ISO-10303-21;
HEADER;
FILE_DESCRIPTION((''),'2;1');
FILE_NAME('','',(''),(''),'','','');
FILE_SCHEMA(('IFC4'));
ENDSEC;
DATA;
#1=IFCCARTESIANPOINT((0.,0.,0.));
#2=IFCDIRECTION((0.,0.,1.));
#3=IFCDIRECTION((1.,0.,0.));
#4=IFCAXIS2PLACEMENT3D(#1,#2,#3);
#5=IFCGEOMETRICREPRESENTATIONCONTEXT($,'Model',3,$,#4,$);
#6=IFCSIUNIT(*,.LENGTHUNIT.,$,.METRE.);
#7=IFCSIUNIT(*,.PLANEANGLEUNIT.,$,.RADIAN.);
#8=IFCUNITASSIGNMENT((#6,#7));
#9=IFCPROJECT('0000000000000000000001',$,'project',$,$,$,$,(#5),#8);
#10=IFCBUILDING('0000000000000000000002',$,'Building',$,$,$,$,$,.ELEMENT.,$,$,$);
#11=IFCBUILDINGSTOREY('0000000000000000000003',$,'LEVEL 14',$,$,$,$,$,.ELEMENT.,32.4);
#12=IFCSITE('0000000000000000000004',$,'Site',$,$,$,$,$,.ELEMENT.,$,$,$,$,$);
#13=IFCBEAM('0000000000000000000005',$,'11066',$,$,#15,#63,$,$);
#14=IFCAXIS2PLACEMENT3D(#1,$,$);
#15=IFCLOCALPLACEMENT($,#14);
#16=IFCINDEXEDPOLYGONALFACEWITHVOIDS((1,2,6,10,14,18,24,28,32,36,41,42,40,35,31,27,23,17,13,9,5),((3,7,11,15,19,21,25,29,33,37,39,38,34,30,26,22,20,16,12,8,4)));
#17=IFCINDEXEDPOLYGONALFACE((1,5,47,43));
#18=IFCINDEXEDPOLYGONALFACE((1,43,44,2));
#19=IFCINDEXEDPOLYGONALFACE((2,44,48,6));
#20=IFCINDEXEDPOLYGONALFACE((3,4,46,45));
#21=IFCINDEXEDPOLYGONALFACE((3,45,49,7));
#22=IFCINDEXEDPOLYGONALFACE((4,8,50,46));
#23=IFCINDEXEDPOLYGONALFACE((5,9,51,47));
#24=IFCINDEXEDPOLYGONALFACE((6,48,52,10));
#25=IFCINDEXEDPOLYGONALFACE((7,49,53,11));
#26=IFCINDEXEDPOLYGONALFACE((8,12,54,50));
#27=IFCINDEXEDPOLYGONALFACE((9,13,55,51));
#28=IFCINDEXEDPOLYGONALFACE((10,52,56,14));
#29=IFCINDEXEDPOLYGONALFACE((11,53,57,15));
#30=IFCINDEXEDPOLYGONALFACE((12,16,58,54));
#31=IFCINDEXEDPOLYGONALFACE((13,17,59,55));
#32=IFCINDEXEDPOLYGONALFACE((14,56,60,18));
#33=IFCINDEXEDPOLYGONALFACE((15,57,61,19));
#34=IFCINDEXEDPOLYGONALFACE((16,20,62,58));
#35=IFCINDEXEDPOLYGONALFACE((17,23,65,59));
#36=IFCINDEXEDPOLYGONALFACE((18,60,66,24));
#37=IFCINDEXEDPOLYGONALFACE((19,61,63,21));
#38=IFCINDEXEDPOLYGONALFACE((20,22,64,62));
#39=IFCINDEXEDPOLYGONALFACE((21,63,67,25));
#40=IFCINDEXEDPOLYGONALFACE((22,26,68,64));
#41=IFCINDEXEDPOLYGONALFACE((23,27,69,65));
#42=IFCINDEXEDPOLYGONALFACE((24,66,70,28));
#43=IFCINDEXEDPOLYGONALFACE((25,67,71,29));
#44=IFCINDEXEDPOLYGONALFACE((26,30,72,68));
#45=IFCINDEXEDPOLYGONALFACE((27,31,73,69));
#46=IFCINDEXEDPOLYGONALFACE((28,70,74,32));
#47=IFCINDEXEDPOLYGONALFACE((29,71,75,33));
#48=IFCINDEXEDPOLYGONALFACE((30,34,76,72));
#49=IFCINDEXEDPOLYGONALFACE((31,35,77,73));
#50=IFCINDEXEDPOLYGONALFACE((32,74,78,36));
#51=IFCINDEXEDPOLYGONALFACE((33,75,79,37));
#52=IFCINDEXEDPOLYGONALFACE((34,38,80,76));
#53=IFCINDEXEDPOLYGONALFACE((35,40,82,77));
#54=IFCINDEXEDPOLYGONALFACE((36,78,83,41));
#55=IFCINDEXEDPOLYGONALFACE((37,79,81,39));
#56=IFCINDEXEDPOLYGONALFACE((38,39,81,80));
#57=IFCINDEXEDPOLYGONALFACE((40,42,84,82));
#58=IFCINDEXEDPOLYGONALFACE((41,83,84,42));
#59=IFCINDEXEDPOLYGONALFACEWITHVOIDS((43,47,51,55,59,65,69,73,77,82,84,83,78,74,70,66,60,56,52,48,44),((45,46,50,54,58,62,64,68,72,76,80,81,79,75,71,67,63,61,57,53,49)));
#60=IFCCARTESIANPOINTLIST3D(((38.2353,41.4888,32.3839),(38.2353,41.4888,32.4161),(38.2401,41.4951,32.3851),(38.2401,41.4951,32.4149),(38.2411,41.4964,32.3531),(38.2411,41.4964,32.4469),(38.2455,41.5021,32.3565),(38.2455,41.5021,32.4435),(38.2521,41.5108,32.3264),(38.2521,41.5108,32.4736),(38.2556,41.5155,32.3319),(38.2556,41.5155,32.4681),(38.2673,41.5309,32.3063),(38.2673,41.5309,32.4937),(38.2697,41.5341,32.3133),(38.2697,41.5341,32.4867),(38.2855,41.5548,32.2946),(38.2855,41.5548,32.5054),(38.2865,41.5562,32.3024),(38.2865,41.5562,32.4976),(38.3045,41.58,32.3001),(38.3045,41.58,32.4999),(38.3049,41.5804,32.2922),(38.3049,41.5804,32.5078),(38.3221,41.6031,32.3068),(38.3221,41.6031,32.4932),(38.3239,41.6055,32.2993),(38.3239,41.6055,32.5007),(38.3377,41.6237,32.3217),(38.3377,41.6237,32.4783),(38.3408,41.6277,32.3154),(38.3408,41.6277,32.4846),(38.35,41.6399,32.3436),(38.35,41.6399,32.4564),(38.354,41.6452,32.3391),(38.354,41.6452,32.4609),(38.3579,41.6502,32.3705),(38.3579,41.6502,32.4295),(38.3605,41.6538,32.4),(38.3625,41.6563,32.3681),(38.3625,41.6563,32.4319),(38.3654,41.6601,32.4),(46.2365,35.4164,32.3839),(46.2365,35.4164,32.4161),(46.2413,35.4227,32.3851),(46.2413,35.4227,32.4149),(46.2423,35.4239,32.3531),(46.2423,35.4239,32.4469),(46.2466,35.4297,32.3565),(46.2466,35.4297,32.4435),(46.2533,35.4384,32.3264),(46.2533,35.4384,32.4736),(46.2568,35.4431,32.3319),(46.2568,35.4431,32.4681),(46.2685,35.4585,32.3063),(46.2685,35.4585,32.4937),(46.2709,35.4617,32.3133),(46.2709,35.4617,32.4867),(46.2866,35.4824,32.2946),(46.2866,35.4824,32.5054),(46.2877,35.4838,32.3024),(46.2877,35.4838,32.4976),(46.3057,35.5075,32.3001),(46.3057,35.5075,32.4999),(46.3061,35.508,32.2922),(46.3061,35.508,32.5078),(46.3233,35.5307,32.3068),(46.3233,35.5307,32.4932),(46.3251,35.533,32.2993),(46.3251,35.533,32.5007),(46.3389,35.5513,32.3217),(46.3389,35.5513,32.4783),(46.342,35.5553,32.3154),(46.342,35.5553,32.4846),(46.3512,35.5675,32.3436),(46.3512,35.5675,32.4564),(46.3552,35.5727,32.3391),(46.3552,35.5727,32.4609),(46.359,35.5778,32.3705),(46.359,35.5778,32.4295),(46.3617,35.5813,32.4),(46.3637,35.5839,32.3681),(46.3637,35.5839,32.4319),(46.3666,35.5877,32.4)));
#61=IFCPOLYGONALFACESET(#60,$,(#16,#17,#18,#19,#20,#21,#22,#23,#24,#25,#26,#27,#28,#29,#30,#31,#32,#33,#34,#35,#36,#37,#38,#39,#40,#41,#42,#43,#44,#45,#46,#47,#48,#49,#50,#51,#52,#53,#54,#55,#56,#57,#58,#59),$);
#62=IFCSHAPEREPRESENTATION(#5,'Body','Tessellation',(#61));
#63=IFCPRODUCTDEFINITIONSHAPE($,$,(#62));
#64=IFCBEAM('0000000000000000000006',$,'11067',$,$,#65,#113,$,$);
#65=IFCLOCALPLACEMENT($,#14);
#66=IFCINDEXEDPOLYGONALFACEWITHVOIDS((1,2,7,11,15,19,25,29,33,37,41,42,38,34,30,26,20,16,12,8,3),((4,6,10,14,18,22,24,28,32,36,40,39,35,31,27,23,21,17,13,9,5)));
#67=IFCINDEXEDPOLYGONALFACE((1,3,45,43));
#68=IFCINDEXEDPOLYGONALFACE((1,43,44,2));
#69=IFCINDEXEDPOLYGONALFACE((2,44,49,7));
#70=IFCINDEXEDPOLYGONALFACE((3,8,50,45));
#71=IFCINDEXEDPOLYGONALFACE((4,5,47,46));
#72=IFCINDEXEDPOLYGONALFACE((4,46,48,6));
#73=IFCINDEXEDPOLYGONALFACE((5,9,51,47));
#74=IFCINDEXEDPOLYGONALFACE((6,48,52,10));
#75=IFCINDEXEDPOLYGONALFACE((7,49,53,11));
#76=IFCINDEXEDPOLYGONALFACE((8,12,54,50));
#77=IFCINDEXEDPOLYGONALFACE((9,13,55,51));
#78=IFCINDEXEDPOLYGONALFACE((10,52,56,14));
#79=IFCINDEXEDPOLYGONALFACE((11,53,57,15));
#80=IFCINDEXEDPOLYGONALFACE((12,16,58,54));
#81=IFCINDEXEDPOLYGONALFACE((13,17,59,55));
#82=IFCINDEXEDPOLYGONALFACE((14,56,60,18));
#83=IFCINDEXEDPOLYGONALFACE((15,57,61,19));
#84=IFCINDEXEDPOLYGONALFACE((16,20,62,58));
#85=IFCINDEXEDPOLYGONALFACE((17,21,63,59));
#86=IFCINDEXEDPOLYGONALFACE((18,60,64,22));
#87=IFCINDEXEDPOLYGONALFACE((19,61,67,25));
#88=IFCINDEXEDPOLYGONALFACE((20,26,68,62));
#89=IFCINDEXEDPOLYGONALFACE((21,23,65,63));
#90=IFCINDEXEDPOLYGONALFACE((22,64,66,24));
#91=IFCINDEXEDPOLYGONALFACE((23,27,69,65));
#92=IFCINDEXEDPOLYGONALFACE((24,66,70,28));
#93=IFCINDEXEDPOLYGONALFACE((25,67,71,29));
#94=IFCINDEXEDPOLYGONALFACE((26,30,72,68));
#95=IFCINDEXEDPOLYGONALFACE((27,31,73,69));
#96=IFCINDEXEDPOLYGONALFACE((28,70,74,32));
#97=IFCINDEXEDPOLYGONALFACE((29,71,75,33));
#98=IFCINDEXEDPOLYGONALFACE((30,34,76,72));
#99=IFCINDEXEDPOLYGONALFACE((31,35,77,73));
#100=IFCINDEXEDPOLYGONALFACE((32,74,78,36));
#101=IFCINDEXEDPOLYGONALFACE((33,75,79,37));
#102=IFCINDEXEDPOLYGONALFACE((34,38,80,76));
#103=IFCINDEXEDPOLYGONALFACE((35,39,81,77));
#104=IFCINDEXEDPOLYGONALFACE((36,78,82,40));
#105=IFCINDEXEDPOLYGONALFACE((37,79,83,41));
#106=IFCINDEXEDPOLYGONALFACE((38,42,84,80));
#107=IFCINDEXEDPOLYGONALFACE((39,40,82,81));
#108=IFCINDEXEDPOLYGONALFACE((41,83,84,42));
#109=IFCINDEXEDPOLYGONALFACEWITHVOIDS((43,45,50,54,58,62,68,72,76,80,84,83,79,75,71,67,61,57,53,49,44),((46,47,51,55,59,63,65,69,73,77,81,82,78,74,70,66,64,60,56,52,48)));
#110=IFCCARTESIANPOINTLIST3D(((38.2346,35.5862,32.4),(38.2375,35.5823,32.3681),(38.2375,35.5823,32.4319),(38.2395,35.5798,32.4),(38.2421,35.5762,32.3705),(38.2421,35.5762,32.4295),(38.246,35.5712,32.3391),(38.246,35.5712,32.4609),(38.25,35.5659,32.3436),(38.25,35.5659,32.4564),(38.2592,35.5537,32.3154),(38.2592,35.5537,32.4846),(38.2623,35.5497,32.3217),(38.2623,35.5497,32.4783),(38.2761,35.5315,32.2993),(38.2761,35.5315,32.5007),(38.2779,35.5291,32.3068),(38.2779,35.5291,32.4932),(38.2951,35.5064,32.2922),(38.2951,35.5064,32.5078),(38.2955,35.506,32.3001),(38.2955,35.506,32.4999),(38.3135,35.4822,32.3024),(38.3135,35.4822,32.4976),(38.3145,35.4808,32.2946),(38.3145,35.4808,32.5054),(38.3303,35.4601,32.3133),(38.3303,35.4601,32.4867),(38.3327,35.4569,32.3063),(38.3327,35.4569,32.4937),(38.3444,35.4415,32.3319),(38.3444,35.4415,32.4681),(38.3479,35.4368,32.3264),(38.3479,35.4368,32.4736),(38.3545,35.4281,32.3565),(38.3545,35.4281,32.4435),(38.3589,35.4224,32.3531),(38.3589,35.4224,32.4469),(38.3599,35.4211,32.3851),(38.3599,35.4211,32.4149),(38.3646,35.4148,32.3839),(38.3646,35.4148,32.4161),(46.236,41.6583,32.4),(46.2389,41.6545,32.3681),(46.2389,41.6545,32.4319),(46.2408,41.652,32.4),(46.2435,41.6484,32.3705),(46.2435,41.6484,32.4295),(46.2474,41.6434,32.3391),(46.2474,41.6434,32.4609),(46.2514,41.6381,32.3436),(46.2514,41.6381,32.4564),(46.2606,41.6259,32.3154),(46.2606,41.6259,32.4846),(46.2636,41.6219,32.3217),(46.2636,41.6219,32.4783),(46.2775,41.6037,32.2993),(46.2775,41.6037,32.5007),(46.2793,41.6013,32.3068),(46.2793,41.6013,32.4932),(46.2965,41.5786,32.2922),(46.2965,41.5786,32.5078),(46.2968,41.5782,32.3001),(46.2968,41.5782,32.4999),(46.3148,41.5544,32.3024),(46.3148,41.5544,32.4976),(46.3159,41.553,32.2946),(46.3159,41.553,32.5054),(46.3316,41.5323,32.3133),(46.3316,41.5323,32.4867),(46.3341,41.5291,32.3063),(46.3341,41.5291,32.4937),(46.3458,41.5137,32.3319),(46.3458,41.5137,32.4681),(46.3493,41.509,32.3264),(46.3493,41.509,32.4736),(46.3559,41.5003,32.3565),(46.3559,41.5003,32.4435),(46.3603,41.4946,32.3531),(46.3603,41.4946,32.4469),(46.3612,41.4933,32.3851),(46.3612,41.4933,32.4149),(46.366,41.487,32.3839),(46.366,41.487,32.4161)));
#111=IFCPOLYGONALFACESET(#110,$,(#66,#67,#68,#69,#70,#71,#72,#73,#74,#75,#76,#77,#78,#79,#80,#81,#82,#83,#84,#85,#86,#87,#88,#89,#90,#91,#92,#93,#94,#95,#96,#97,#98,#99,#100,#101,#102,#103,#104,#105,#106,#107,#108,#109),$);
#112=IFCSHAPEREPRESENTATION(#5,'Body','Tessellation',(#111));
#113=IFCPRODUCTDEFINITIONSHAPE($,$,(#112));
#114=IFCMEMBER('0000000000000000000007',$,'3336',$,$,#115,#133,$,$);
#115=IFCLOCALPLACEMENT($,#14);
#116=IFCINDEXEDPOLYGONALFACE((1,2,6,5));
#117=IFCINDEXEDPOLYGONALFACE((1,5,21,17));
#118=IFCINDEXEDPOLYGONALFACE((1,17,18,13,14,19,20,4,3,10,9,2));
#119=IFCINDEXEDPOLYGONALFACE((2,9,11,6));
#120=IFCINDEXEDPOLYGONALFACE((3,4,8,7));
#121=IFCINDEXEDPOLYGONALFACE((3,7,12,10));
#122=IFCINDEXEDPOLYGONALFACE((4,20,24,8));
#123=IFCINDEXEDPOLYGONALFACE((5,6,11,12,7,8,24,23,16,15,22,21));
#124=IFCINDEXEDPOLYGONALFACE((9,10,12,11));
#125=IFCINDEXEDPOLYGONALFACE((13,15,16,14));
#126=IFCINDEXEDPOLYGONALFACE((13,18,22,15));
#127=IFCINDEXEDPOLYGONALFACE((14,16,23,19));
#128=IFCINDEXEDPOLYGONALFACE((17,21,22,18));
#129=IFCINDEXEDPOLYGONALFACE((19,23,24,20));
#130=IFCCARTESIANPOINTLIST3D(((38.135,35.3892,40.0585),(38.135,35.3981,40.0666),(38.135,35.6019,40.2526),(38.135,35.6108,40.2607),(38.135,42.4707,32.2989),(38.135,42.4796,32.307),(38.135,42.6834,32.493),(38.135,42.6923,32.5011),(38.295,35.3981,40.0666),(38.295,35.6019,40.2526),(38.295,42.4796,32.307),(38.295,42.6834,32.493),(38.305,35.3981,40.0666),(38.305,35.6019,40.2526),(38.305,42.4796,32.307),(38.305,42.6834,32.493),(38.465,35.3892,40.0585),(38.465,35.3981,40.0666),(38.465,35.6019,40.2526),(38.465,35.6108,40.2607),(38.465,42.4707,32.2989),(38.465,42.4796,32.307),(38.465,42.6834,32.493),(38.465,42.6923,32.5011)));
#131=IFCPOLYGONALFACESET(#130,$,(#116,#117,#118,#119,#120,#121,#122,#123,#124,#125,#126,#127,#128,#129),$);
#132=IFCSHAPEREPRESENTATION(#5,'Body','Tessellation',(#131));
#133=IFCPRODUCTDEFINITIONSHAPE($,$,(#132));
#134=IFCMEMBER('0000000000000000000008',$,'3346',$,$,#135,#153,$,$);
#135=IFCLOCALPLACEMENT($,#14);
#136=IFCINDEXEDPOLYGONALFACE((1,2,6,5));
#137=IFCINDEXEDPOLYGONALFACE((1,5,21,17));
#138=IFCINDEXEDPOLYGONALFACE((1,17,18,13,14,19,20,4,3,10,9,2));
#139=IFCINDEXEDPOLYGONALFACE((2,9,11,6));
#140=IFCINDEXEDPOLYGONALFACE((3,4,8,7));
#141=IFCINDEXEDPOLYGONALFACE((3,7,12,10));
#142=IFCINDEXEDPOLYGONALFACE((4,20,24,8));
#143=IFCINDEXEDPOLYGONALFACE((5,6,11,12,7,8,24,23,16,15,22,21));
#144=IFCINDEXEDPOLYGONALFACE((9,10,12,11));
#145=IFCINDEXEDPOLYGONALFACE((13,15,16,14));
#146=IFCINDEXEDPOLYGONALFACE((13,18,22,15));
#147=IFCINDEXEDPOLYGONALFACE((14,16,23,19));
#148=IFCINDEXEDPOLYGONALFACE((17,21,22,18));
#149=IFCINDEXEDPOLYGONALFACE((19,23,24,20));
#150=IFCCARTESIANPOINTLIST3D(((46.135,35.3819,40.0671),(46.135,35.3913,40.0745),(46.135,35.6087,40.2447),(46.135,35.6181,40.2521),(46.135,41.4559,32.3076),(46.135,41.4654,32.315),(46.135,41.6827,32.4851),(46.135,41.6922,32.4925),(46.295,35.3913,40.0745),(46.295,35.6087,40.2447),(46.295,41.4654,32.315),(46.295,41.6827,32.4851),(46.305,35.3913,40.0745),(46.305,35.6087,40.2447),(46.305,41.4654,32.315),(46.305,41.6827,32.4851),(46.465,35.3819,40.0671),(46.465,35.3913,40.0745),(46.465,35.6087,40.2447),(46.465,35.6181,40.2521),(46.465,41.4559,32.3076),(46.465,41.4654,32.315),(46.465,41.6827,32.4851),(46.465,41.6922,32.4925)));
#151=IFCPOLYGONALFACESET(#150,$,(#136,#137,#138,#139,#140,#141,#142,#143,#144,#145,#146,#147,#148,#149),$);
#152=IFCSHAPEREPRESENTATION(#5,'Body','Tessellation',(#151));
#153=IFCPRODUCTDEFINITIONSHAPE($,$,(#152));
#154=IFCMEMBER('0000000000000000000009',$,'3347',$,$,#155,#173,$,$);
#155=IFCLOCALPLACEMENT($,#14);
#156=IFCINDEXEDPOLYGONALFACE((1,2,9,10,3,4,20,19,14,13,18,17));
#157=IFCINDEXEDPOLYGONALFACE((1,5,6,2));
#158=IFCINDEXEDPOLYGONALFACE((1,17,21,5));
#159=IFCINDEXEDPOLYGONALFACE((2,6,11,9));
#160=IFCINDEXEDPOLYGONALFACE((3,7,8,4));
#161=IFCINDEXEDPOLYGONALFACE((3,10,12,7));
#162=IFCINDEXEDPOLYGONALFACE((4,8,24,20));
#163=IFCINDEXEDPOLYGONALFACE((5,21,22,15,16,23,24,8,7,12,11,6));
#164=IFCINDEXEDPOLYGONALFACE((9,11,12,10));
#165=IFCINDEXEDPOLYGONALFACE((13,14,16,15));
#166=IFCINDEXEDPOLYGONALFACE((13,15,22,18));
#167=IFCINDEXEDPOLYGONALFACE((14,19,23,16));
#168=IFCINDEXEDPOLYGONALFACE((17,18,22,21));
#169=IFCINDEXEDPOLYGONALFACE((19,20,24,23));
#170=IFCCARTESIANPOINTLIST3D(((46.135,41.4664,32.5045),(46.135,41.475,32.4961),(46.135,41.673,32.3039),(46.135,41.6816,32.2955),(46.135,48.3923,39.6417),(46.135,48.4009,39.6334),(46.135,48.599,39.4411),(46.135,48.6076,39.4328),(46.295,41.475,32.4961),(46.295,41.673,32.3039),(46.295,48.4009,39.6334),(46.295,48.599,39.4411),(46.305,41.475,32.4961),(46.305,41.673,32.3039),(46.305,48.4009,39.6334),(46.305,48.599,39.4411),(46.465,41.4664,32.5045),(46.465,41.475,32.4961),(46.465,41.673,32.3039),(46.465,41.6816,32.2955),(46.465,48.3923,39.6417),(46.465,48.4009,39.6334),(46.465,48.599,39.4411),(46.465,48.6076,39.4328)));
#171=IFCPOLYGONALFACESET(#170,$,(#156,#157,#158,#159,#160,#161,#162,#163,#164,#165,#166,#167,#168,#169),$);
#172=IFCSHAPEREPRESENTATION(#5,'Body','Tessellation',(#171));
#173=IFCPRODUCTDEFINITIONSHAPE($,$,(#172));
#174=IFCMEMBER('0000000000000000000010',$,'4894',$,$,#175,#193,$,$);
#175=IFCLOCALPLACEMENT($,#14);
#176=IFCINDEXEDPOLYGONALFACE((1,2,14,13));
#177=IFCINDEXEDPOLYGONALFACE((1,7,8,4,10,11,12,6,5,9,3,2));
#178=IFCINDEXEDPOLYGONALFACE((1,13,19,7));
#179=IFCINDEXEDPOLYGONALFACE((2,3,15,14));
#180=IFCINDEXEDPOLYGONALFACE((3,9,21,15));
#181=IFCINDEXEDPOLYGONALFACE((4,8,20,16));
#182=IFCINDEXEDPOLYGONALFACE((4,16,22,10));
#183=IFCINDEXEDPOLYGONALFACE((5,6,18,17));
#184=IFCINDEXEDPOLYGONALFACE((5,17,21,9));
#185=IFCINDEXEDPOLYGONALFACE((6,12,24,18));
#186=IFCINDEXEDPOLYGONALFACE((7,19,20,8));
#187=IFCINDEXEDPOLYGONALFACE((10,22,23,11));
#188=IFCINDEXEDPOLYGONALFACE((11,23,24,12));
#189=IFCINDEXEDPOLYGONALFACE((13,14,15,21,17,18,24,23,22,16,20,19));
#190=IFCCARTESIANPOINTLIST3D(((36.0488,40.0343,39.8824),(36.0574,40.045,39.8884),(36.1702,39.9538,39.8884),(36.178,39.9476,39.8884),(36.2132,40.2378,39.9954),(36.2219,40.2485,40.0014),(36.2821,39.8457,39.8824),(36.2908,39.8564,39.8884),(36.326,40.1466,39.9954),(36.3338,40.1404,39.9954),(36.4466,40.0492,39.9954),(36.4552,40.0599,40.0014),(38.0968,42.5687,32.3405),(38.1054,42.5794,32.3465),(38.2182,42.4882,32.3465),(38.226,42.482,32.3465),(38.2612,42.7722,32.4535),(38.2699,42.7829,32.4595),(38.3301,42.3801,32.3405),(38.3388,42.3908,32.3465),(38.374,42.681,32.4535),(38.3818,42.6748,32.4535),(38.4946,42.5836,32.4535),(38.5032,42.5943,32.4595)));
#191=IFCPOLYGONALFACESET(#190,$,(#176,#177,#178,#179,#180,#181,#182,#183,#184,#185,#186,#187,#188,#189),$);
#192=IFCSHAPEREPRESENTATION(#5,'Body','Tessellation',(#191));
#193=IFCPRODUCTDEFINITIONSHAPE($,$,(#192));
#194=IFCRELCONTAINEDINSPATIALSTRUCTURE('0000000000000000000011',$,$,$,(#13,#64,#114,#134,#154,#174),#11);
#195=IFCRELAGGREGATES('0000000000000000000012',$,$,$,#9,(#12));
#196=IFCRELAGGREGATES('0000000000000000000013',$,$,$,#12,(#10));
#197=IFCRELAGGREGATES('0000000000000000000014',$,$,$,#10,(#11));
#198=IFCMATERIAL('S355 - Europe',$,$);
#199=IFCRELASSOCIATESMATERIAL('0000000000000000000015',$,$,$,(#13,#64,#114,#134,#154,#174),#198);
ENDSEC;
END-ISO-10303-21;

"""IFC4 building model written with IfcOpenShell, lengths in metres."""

from ifc_helpers import new_model, si_unit, frame, origin_with_axes, origin_2d_with_axis, place, context, project, spatial, hollow_circle, i_section, extrude, material, material_profile, profile_set, profile_usage, element, save


model = new_model("IFC4")

# Units and contexts
model_context = context("Model", 3, world=origin_with_axes())
ifc_project = project(units=[si_unit("LENGTHUNIT", "METRE"), si_unit("PLANEANGLEUNIT", "RADIAN")], contexts=[model_context])

# Site, building, storey
site = spatial("IfcSite", under=ifc_project, Name="Site", CompositionType="ELEMENT")
building = spatial("IfcBuilding", under=site, Name="Building", CompositionType="ELEMENT")
storey = spatial("IfcBuildingStorey", under=building, Name="LEVEL 14", CompositionType="ELEMENT", Elevation=32.4)

# Shared definitions
ifc_material = material(Name="S355 - Europe")

# Beams
ifc_material_profile_1 = material_profile(ifc_material, hollow_circle(Radius=0.1081, WallThickness=0.008, at=origin_2d_with_axis()))
ifc_profile_set_1 = profile_set([ifc_material_profile_1])
ifc_profile_usage_1 = profile_usage(ifc_profile_set_1, cardinal=10)
beam_1_placement = place(None, frame((38.3, 41.574, 32.4), z_axis=(0.796568, -0.604549, 0.0), x_axis=(0.604647, 0.796493, 0.0)))
element("IfcBeam", 1, at=beam_1_placement, inside=storey, material=ifc_profile_usage_1, Name="11066", context=model_context, shape_type="SweptSolid", body=[
    extrude(hollow_circle(Radius=0.1081, WallThickness=0.008, at=origin_2d_with_axis()), origin_with_axes(), (0.0, 0.0, 1.0), 10.0446),
])
ifc_material_profile_2 = material_profile(ifc_material, hollow_circle(Radius=0.1081, WallThickness=0.008, at=origin_2d_with_axis()))
ifc_profile_set_2 = profile_set([ifc_material_profile_2])
ifc_profile_usage_2 = profile_usage(ifc_profile_set_2, cardinal=10)
beam_2_placement = place(None, frame((38.3, 35.5, 32.4), z_axis=(0.796587, 0.604524, 0.0), x_axis=(-0.604647, 0.796493, 0.0)))
element("IfcBeam", 2, at=beam_2_placement, inside=storey, material=ifc_profile_usage_2, Name="11067", context=model_context, shape_type="SweptSolid", body=[
    extrude(hollow_circle(Radius=0.1081, WallThickness=0.008, at=origin_2d_with_axis()), origin_with_axes(), (0.0, 0.0, 1.0), 10.0446),
])

# Members
ifc_material_profile_3 = material_profile(ifc_material, i_section(OverallWidth=0.33, OverallDepth=0.3, WebThickness=0.01, FlangeThickness=0.012, at=origin_2d_with_axis()))
ifc_profile_set_3 = profile_set([ifc_material_profile_3])
ifc_profile_usage_3 = profile_usage(ifc_profile_set_3, cardinal=10)
member_1_placement = place(None, frame((38.3, 35.5, 40.1596), z_axis=(0.0, 0.674095, -0.738644), x_axis=(-1.0, 0.0, 0.0)))
element("IfcMember", 3, at=member_1_placement, inside=storey, material=ifc_profile_usage_3, Name="3336", context=model_context, shape_type="SweptSolid", body=[
    extrude(i_section(OverallWidth=0.33, OverallDepth=0.3, WebThickness=0.01, FlangeThickness=0.012, at=origin_2d_with_axis()), origin_with_axes(), (0.0, 0.0, 1.0), 10.5052),
])
ifc_material_profile_4 = material_profile(ifc_material, i_section(OverallWidth=0.33, OverallDepth=0.3, WebThickness=0.01, FlangeThickness=0.012, at=origin_2d_with_axis()))
ifc_profile_set_4 = profile_set([ifc_material_profile_4])
ifc_profile_usage_4 = profile_usage(ifc_profile_set_4, cardinal=10)
member_2_placement = place(None, frame((46.3, 35.5, 40.1596), z_axis=(0.0, 0.616394, -0.787438), x_axis=(-1.0, 0.0, 0.0)))
element("IfcMember", 4, at=member_2_placement, inside=storey, material=ifc_profile_usage_4, Name="3346", context=model_context, shape_type="SweptSolid", body=[
    extrude(i_section(OverallWidth=0.33, OverallDepth=0.3, WebThickness=0.01, FlangeThickness=0.012, at=origin_2d_with_axis()), origin_with_axes(), (0.0, 0.0, 1.0), 9.8542),
])
ifc_material_profile_5 = material_profile(ifc_material, i_section(OverallWidth=0.33, OverallDepth=0.3, WebThickness=0.01, FlangeThickness=0.012, at=origin_2d_with_axis()))
ifc_profile_set_5 = profile_set([ifc_material_profile_5])
ifc_profile_usage_5 = profile_usage(ifc_profile_set_5, cardinal=10)
member_3_placement = place(None, frame((46.3, 41.574, 32.4), z_axis=(0.0, 0.696404, 0.71765), x_axis=(-1.0, 0.0, 0.0)))
element("IfcMember", 5, at=member_3_placement, inside=storey, material=ifc_profile_usage_5, Name="3347", context=model_context, shape_type="SweptSolid", body=[
    extrude(i_section(OverallWidth=0.33, OverallDepth=0.3, WebThickness=0.01, FlangeThickness=0.012, at=origin_2d_with_axis()), origin_with_axes(), (0.0, 0.0, 1.0), 9.9453),
])
ifc_material_profile_6 = material_profile(ifc_material, i_section(OverallWidth=0.3, OverallDepth=0.3, WebThickness=0.01, FlangeThickness=0.015, at=origin_2d_with_axis()))
ifc_profile_set_6 = profile_set([ifc_material_profile_6])
ifc_profile_usage_6 = profile_usage(ifc_profile_set_6, cardinal=10)
member_4_placement = place(None, frame((36.252, 40.0471, 39.9419), z_axis=(0.249279, 0.308482, -0.917986), x_axis=(-0.777826, 0.62848, 0.0)))
element("IfcMember", 6, at=member_4_placement, inside=storey, material=ifc_profile_usage_6, Name="4894", context=model_context, shape_type="SweptSolid", body=[
    extrude(i_section(OverallWidth=0.3, OverallDepth=0.3, WebThickness=0.01, FlangeThickness=0.015, at=origin_2d_with_axis()), origin_with_axes(), (0.0, 0.0, 1.0), 8.2157),
])

save(model, "model.ifc")
